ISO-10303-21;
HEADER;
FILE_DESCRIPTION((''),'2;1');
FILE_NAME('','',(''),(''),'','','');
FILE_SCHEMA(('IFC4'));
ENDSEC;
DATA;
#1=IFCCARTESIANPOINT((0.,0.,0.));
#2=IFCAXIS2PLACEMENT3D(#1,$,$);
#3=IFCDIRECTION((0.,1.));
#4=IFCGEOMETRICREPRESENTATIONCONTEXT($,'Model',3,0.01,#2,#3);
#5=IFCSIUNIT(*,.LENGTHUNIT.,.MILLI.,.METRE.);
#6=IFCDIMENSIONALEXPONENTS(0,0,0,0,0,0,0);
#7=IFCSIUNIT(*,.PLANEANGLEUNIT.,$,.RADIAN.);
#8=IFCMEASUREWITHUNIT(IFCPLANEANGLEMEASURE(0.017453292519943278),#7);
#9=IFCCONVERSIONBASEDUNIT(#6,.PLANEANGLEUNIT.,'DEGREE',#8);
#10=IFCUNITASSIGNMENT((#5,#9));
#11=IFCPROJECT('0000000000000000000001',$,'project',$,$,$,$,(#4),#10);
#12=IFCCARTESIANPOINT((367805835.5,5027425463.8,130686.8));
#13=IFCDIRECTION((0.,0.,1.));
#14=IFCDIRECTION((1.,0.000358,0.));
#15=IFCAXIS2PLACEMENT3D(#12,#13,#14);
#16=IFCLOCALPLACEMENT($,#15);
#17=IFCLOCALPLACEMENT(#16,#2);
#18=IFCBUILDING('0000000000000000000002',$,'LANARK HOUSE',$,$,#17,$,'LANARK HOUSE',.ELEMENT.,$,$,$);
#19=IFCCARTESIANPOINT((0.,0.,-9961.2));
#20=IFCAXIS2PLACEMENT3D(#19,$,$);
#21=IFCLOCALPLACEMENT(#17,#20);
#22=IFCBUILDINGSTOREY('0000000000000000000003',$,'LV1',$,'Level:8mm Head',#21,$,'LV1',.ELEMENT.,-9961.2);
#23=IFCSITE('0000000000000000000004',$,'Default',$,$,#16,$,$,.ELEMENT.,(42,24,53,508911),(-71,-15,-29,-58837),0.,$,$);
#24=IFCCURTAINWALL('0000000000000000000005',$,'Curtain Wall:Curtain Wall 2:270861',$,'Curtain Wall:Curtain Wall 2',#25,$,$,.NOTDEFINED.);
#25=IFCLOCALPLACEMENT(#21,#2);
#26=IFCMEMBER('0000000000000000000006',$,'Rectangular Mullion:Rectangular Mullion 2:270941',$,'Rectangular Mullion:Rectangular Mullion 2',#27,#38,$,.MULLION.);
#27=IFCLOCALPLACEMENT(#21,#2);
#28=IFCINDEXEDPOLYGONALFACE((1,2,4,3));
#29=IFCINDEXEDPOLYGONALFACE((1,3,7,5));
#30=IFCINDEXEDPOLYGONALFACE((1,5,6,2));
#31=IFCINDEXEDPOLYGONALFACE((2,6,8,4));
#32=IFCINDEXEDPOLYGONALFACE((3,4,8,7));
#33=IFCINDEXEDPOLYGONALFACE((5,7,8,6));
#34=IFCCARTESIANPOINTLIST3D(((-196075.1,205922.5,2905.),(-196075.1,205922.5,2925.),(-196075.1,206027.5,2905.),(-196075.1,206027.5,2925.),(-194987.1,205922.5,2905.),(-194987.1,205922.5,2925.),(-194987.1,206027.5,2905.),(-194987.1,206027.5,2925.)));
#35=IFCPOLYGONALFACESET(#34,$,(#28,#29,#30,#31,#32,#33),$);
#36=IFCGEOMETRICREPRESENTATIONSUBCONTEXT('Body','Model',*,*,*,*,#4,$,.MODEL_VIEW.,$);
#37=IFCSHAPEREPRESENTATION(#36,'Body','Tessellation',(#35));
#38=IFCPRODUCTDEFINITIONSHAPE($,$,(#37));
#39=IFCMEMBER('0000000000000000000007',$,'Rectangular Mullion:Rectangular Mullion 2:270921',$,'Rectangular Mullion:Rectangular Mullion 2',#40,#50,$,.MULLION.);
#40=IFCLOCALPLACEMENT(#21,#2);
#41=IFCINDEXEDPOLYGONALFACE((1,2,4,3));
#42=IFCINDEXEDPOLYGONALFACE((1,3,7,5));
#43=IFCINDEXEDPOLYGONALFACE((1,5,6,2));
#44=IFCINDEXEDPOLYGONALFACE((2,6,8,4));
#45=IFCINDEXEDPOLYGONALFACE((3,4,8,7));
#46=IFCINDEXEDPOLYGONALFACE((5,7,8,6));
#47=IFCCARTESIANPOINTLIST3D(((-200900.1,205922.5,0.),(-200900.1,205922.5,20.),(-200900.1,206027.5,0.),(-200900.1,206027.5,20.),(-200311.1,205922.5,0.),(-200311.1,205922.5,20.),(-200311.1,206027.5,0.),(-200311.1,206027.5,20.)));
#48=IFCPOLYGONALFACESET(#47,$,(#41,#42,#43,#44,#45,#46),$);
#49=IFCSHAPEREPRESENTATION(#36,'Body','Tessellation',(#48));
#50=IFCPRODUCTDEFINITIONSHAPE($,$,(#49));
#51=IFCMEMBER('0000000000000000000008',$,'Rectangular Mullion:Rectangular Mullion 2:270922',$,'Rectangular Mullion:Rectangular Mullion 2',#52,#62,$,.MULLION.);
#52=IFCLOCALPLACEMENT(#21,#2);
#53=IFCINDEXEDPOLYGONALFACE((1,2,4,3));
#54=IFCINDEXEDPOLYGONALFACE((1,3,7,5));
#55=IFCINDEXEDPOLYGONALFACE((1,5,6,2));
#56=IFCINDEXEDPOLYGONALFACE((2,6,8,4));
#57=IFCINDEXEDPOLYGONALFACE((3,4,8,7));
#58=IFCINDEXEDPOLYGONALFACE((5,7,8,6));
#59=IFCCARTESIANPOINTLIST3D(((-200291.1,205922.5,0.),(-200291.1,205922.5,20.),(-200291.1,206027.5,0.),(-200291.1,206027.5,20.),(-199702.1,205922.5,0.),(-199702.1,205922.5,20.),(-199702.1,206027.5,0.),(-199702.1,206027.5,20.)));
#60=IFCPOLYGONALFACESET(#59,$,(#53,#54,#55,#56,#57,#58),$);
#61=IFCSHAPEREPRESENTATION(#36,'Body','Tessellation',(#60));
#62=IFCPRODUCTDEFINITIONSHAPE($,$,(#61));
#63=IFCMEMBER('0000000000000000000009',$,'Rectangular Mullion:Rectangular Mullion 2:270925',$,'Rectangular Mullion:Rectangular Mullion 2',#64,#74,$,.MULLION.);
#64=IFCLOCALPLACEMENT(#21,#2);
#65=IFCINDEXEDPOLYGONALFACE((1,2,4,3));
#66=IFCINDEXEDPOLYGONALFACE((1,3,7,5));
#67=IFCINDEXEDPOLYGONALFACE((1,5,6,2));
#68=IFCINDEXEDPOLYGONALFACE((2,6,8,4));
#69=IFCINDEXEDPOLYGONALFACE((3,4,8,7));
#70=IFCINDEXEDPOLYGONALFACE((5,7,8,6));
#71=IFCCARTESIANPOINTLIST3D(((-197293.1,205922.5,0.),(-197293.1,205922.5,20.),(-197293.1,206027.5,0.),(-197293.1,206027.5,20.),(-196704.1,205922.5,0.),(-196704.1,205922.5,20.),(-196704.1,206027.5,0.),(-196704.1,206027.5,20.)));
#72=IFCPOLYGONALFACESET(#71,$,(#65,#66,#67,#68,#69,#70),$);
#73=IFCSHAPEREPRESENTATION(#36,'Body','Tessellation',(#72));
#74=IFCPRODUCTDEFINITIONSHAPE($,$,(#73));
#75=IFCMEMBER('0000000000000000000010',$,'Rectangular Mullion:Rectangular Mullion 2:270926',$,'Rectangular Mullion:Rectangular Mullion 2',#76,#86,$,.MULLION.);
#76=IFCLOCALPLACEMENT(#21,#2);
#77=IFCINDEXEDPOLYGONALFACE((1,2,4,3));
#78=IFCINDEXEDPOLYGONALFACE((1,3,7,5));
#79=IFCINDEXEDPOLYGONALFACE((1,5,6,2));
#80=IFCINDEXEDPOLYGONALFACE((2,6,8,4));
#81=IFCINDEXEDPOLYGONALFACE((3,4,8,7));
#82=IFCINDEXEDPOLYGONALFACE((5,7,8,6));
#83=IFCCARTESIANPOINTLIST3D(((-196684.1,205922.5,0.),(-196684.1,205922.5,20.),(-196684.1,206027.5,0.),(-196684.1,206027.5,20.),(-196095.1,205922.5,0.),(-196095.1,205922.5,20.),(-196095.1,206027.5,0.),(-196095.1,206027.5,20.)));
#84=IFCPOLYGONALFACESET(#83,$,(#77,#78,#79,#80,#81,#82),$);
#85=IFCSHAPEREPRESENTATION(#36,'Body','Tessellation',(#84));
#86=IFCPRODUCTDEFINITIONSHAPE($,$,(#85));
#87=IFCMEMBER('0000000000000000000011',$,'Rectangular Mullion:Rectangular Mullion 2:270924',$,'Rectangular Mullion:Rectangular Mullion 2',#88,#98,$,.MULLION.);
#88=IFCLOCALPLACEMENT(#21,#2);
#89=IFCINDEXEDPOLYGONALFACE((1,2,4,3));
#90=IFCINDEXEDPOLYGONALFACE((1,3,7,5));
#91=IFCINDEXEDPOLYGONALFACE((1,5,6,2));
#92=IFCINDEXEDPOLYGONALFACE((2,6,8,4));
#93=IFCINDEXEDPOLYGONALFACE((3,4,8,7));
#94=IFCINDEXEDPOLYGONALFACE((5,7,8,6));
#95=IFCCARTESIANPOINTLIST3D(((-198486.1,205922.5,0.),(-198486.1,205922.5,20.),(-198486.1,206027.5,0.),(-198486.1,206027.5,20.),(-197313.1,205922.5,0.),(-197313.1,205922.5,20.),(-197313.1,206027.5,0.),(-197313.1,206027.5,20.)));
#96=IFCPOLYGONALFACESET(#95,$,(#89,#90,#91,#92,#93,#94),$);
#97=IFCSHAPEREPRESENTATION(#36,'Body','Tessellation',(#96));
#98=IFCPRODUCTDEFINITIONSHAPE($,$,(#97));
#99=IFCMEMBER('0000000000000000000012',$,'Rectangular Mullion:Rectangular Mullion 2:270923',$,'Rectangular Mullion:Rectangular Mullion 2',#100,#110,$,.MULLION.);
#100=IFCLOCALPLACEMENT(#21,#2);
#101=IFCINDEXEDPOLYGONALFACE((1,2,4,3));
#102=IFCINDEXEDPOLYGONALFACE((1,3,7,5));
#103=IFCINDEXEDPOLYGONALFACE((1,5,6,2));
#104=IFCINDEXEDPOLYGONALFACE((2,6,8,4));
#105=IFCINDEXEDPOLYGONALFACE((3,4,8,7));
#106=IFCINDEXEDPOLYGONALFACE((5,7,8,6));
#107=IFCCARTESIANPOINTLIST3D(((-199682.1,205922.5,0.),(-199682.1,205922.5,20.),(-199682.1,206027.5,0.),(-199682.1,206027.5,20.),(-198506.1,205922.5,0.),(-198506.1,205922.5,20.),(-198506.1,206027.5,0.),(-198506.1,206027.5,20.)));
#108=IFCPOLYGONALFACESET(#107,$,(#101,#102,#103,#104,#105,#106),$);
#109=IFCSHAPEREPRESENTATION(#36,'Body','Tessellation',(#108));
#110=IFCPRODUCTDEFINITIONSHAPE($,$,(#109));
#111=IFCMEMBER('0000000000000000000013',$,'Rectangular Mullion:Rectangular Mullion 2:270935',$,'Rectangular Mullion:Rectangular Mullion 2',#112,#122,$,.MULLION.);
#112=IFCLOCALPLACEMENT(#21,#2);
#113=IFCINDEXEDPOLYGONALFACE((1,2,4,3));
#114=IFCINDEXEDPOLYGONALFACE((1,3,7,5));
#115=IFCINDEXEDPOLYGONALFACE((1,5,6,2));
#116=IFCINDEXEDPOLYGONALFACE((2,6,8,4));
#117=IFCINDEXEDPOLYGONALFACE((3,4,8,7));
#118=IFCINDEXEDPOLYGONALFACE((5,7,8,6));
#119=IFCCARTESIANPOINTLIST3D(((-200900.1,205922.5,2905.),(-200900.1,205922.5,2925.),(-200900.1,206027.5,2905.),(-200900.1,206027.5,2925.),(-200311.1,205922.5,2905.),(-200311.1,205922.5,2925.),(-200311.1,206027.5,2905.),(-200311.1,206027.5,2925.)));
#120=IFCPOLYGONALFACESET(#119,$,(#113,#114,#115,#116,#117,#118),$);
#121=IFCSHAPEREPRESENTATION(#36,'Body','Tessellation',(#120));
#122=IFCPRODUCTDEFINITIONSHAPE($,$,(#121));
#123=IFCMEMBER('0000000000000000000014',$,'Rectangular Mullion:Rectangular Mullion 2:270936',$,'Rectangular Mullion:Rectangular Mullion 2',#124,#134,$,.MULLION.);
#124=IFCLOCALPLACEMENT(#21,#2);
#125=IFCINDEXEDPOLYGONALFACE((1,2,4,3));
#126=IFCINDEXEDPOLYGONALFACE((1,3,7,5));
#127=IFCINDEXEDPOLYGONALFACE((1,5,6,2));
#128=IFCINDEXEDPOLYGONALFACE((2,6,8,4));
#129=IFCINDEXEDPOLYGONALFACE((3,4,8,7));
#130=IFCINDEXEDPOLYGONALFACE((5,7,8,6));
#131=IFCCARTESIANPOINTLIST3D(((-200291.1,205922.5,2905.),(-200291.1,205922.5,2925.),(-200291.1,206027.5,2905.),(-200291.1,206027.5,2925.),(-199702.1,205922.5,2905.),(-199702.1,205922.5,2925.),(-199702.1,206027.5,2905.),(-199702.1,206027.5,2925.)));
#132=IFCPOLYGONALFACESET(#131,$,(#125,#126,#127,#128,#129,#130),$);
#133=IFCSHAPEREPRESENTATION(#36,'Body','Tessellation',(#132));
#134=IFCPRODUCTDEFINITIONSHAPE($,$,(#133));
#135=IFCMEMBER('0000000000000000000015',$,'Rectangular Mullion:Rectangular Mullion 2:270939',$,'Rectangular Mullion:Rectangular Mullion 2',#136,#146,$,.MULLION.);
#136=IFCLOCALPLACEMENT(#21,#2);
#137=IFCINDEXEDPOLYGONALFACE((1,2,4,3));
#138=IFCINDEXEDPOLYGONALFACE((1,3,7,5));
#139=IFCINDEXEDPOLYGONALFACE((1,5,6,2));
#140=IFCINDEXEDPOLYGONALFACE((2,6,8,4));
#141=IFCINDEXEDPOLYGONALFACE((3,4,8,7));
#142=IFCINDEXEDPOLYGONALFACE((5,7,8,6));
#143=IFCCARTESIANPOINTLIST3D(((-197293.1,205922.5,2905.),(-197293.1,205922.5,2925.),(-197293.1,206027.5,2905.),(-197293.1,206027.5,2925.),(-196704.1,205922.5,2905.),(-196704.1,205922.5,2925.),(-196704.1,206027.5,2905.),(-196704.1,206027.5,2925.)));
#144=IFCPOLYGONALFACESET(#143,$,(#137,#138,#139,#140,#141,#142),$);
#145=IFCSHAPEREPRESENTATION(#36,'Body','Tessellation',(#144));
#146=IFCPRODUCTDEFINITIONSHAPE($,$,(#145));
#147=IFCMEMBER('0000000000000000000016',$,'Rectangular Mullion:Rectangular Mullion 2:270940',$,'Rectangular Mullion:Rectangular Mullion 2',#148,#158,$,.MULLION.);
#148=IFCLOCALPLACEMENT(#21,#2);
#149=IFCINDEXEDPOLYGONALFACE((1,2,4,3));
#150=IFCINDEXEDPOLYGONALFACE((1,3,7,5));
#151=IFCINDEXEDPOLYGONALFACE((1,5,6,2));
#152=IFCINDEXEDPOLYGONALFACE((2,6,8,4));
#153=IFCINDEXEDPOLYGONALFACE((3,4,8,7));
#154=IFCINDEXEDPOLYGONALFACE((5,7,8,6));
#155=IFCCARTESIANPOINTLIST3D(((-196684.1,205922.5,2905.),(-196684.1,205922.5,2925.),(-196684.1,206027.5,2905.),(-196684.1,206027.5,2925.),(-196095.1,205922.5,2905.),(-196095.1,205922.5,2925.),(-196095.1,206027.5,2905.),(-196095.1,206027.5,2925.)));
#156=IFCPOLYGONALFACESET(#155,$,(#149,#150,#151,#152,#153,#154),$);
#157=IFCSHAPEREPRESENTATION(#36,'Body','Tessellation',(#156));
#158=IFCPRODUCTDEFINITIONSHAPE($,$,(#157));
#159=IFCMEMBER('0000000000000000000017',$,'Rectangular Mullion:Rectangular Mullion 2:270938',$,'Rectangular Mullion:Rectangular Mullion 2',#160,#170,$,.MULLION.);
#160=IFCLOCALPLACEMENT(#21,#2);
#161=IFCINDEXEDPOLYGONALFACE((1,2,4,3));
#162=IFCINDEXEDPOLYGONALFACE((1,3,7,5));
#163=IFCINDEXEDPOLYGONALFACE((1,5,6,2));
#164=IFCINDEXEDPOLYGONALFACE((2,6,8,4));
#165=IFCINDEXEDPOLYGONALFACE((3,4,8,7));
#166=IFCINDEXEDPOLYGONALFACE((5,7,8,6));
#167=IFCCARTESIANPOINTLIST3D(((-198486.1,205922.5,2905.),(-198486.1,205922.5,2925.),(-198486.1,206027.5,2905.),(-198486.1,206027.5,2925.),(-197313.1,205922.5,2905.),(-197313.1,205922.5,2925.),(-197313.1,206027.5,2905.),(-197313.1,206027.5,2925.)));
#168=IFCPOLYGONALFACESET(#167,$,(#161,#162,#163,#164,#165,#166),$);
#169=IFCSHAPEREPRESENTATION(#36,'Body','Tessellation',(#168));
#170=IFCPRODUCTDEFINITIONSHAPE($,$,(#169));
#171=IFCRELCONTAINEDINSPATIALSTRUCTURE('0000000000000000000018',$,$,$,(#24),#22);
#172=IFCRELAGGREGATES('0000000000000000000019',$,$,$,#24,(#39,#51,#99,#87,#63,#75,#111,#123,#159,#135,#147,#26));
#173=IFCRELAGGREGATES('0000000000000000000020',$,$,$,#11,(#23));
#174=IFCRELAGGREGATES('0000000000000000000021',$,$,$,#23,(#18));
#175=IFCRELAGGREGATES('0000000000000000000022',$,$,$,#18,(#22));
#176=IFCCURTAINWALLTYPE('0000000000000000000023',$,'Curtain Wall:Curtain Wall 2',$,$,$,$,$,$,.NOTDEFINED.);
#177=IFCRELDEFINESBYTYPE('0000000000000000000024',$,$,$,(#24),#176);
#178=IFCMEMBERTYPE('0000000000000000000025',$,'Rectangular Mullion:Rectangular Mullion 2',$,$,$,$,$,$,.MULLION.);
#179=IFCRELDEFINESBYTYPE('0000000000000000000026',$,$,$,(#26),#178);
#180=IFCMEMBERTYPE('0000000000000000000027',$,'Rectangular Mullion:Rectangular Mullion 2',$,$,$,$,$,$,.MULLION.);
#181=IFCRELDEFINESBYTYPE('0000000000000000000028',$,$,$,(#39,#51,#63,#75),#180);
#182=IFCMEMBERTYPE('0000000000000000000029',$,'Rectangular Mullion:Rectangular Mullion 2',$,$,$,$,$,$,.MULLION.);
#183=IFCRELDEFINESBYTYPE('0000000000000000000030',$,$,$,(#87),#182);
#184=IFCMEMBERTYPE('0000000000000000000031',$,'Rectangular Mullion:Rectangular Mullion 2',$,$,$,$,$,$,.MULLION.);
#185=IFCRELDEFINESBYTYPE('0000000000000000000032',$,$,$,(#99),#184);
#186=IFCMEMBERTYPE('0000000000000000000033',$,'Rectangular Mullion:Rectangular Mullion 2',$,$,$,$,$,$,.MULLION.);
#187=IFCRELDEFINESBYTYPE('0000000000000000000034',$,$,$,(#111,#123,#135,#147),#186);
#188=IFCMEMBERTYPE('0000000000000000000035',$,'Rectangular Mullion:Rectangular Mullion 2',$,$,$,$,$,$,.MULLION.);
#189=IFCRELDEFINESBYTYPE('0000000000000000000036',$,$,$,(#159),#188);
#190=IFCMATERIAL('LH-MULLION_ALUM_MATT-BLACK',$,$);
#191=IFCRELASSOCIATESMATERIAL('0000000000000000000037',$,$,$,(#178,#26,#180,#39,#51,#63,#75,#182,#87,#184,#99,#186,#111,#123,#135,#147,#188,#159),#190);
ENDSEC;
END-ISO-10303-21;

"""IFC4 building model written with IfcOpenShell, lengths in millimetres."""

from ifc_helpers import new_model, entity, si_unit, converted_unit, direction, frame, origin, place, context, subcontext, project, spatial, indexed_curve, outline, extrude, source, transform, mapped, material, type_object, type_shapes, element, aggregate, save


model = new_model("IFC4")

# Units and contexts
model_context = context("Model", 3, precision=0.01, world=origin(), true_north=direction((0.0, 1.0)))
body_context = subcontext(model_context, "Body", "Model", "MODEL_VIEW")
ifc_project = project(units=[si_unit("LENGTHUNIT", "METRE", prefix="MILLI"), converted_unit("PLANEANGLEUNIT", "DEGREE", entity("IfcPlaneAngleMeasure", 0.017453292519943278), si_unit("PLANEANGLEUNIT", "RADIAN"), dimensions=[0, 0, 0, 0, 0, 0, 0])], contexts=[model_context])

# Site, building, storey
site_placement = place(None, frame((367805835.5, 5027425463.8, 130686.8), z_axis=(0.0, 0.0, 1.0), x_axis=(1.0, 0.000358, 0.0)))
site = spatial("IfcSite", under=ifc_project, at=site_placement, Name="Default", CompositionType="ELEMENT", RefLatitude=(42, 24, 53, 508911), RefLongitude=(-71, -15, -29, -58837), RefElevation=0.0)
building_placement = place(site_placement, origin())
building = spatial("IfcBuilding", under=site, at=building_placement, Name="LANARK HOUSE", LongName="LANARK HOUSE", CompositionType="ELEMENT")
storey_placement = place(building_placement, frame((0.0, 0.0, -9961.2)))
storey = spatial("IfcBuildingStorey", under=building, at=storey_placement, Name="LV1", ObjectType="Level:8mm Head", LongName="LV1", CompositionType="ELEMENT", Elevation=-9961.2)

# Curtain wall, members
curtain_wall_type = type_object("IfcCurtainWallType", Name="Curtain Wall:Curtain Wall 2", PredefinedType="NOTDEFINED")
curtain_wall_placement = place(storey_placement, frame((0.0, 0.0, 9961.2)))
curtain_wall = element("IfcCurtainWall", 1, at=curtain_wall_placement, inside=storey, type_object=curtain_wall_type, Name="Curtain Wall:Curtain Wall 2:270861", ObjectType="Curtain Wall:Curtain Wall 2", PredefinedType="NOTDEFINED")
ifc_material_1 = material(Name="LH-MULLION_ALUM_MATT-BLACK")
member_type_1 = type_object("IfcMemberType", Name="Rectangular Mullion:Rectangular Mullion 2", PredefinedType="MULLION", material=ifc_material_1)
shared_shape_1 = source(origin(), body_context, "Body", "SweptSolid", [
    extrude(outline(indexed_curve([(-10.0, -52.5), (10.0, -52.5), (10.0, 52.5), (-10.0, 52.5), (-10.0, -52.5)], self_intersect=False)), frame((-10.0, -40.0, -1088.0), z_axis=(0.0, 0.0, 1.0), x_axis=(-1.0, 0.0, 0.0)), (0.0, 0.0, 1.0), 1088.0),
])
type_shapes(member_type_1, [shared_shape_1])
member_1_placement = place(curtain_wall_placement, frame((-196075.1, 206015.0, -7036.2), z_axis=(-1.0, 0.0, 0.0), x_axis=(0.0, 0.0, 1.0)))
member_1 = element("IfcMember", 2, at=member_1_placement, type_object=member_type_1, material=ifc_material_1, Name="Rectangular Mullion:Rectangular Mullion 2:270941", ObjectType="Rectangular Mullion:Rectangular Mullion 2", PredefinedType="MULLION", context=body_context, shape_type="MappedRepresentation", body=[
    mapped(shared_shape_1, transform((0.0, 0.0, 0.0), scale=1.0)),
])
member_type_2 = type_object("IfcMemberType", Name="Rectangular Mullion:Rectangular Mullion 2", PredefinedType="MULLION", material=ifc_material_1)
shared_shape_2 = source(origin(), body_context, "Body", "SweptSolid", [
    extrude(outline(indexed_curve([(-10.0, -52.5), (10.0, -52.5), (10.0, 52.5), (-10.0, 52.5), (-10.0, -52.5)], self_intersect=False)), frame((-10.0, -40.0, -589.0), z_axis=(0.0, 0.0, 1.0), x_axis=(-1.0, 0.0, 0.0)), (0.0, 0.0, 1.0), 589.0),
])
type_shapes(member_type_2, [shared_shape_2])
member_2_placement = place(curtain_wall_placement, frame((-200311.1, 206015.0, -9961.2), z_axis=(1.0, 0.0, 0.0), x_axis=(0.0, 0.0, -1.0)))
member_2 = element("IfcMember", 3, at=member_2_placement, type_object=member_type_2, material=ifc_material_1, Name="Rectangular Mullion:Rectangular Mullion 2:270921", ObjectType="Rectangular Mullion:Rectangular Mullion 2", PredefinedType="MULLION", context=body_context, shape_type="MappedRepresentation", body=[
    mapped(shared_shape_2, transform((0.0, 0.0, 0.0), scale=1.0)),
])
member_3_placement = place(curtain_wall_placement, frame((-199702.1, 206015.0, -9961.2), z_axis=(1.0, 0.0, 0.0), x_axis=(0.0, 0.0, -1.0)))
member_3 = element("IfcMember", 4, at=member_3_placement, type_object=member_type_2, material=ifc_material_1, Name="Rectangular Mullion:Rectangular Mullion 2:270922", ObjectType="Rectangular Mullion:Rectangular Mullion 2", PredefinedType="MULLION", context=body_context, shape_type="MappedRepresentation", body=[
    mapped(shared_shape_2, transform((0.0, 0.0, 0.0), scale=1.0)),
])
member_4_placement = place(curtain_wall_placement, frame((-196704.1, 206015.0, -9961.2), z_axis=(1.0, 0.0, 0.0), x_axis=(0.0, 0.0, -1.0)))
member_4 = element("IfcMember", 5, at=member_4_placement, type_object=member_type_2, material=ifc_material_1, Name="Rectangular Mullion:Rectangular Mullion 2:270925", ObjectType="Rectangular Mullion:Rectangular Mullion 2", PredefinedType="MULLION", context=body_context, shape_type="MappedRepresentation", body=[
    mapped(shared_shape_2, transform((0.0, 0.0, 0.0), scale=1.0)),
])
member_5_placement = place(curtain_wall_placement, frame((-196095.1, 206015.0, -9961.2), z_axis=(1.0, 0.0, 0.0), x_axis=(0.0, 0.0, -1.0)))
member_5 = element("IfcMember", 6, at=member_5_placement, type_object=member_type_2, material=ifc_material_1, Name="Rectangular Mullion:Rectangular Mullion 2:270926", ObjectType="Rectangular Mullion:Rectangular Mullion 2", PredefinedType="MULLION", context=body_context, shape_type="MappedRepresentation", body=[
    mapped(shared_shape_2, transform((0.0, 0.0, 0.0), scale=1.0)),
])
member_type_3 = type_object("IfcMemberType", Name="Rectangular Mullion:Rectangular Mullion 2", PredefinedType="MULLION", material=ifc_material_1)
shared_shape_3 = source(origin(), body_context, "Body", "SweptSolid", [
    extrude(outline(indexed_curve([(-10.0, -52.5), (10.0, -52.5), (10.0, 52.5), (-10.0, 52.5), (-10.0, -52.5)], self_intersect=False)), frame((-10.0, -40.0, -1173.0), z_axis=(0.0, 0.0, 1.0), x_axis=(-1.0, 0.0, 0.0)), (0.0, 0.0, 1.0), 1173.0),
])
type_shapes(member_type_3, [shared_shape_3])
member_6_placement = place(curtain_wall_placement, frame((-197313.1, 206015.0, -9961.2), z_axis=(1.0, 0.0, 0.0), x_axis=(0.0, 0.0, -1.0)))
member_6 = element("IfcMember", 7, at=member_6_placement, type_object=member_type_3, material=ifc_material_1, Name="Rectangular Mullion:Rectangular Mullion 2:270924", ObjectType="Rectangular Mullion:Rectangular Mullion 2", PredefinedType="MULLION", context=body_context, shape_type="MappedRepresentation", body=[
    mapped(shared_shape_3, transform((0.0, 0.0, 0.0), scale=1.0)),
])
member_type_4 = type_object("IfcMemberType", Name="Rectangular Mullion:Rectangular Mullion 2", PredefinedType="MULLION", material=ifc_material_1)
shared_shape_4 = source(origin(), body_context, "Body", "SweptSolid", [
    extrude(outline(indexed_curve([(-10.0, -52.5), (10.0, -52.5), (10.0, 52.5), (-10.0, 52.5), (-10.0, -52.5)], self_intersect=False)), frame((-10.0, -40.0, -1176.0), z_axis=(0.0, 0.0, 1.0), x_axis=(-1.0, 0.0, 0.0)), (0.0, 0.0, 1.0), 1176.0),
])
type_shapes(member_type_4, [shared_shape_4])
member_7_placement = place(curtain_wall_placement, frame((-198506.1, 206015.0, -9961.2), z_axis=(1.0, 0.0, 0.0), x_axis=(0.0, 0.0, -1.0)))
member_7 = element("IfcMember", 8, at=member_7_placement, type_object=member_type_4, material=ifc_material_1, Name="Rectangular Mullion:Rectangular Mullion 2:270923", ObjectType="Rectangular Mullion:Rectangular Mullion 2", PredefinedType="MULLION", context=body_context, shape_type="MappedRepresentation", body=[
    mapped(shared_shape_4, transform((0.0, 0.0, 0.0), scale=1.0)),
])
member_type_5 = type_object("IfcMemberType", Name="Rectangular Mullion:Rectangular Mullion 2", PredefinedType="MULLION", material=ifc_material_1)
shared_shape_5 = source(origin(), body_context, "Body", "SweptSolid", [
    extrude(outline(indexed_curve([(-10.0, -52.5), (10.0, -52.5), (10.0, 52.5), (-10.0, 52.5), (-10.0, -52.5)], self_intersect=False)), frame((-10.0, -40.0, -589.0), z_axis=(0.0, 0.0, 1.0), x_axis=(-1.0, 0.0, 0.0)), (0.0, 0.0, 1.0), 589.0),
])
type_shapes(member_type_5, [shared_shape_5])
member_8_placement = place(curtain_wall_placement, frame((-200900.1, 206015.0, -7036.2), z_axis=(-1.0, 0.0, 0.0), x_axis=(0.0, 0.0, 1.0)))
member_8 = element("IfcMember", 9, at=member_8_placement, type_object=member_type_5, material=ifc_material_1, Name="Rectangular Mullion:Rectangular Mullion 2:270935", ObjectType="Rectangular Mullion:Rectangular Mullion 2", PredefinedType="MULLION", context=body_context, shape_type="MappedRepresentation", body=[
    mapped(shared_shape_5, transform((0.0, 0.0, 0.0), scale=1.0)),
])
member_9_placement = place(curtain_wall_placement, frame((-200291.1, 206015.0, -7036.2), z_axis=(-1.0, 0.0, 0.0), x_axis=(0.0, 0.0, 1.0)))
member_9 = element("IfcMember", 10, at=member_9_placement, type_object=member_type_5, material=ifc_material_1, Name="Rectangular Mullion:Rectangular Mullion 2:270936", ObjectType="Rectangular Mullion:Rectangular Mullion 2", PredefinedType="MULLION", context=body_context, shape_type="MappedRepresentation", body=[
    mapped(shared_shape_5, transform((0.0, 0.0, 0.0), scale=1.0)),
])
member_10_placement = place(curtain_wall_placement, frame((-197293.1, 206015.0, -7036.2), z_axis=(-1.0, 0.0, 0.0), x_axis=(0.0, 0.0, 1.0)))
member_10 = element("IfcMember", 11, at=member_10_placement, type_object=member_type_5, material=ifc_material_1, Name="Rectangular Mullion:Rectangular Mullion 2:270939", ObjectType="Rectangular Mullion:Rectangular Mullion 2", PredefinedType="MULLION", context=body_context, shape_type="MappedRepresentation", body=[
    mapped(shared_shape_5, transform((0.0, 0.0, 0.0), scale=1.0)),
])
member_11_placement = place(curtain_wall_placement, frame((-196684.1, 206015.0, -7036.2), z_axis=(-1.0, 0.0, 0.0), x_axis=(0.0, 0.0, 1.0)))
member_11 = element("IfcMember", 12, at=member_11_placement, type_object=member_type_5, material=ifc_material_1, Name="Rectangular Mullion:Rectangular Mullion 2:270940", ObjectType="Rectangular Mullion:Rectangular Mullion 2", PredefinedType="MULLION", context=body_context, shape_type="MappedRepresentation", body=[
    mapped(shared_shape_5, transform((0.0, 0.0, 0.0), scale=1.0)),
])
member_type_6 = type_object("IfcMemberType", Name="Rectangular Mullion:Rectangular Mullion 2", PredefinedType="MULLION", material=ifc_material_1)
shared_shape_6 = source(origin(), body_context, "Body", "SweptSolid", [
    extrude(outline(indexed_curve([(-10.0, -52.5), (10.0, -52.5), (10.0, 52.5), (-10.0, 52.5), (-10.0, -52.5)], self_intersect=False)), frame((-10.0, -40.0, -1173.0), z_axis=(0.0, 0.0, 1.0), x_axis=(-1.0, 0.0, 0.0)), (0.0, 0.0, 1.0), 1173.0),
])
type_shapes(member_type_6, [shared_shape_6])
member_12_placement = place(curtain_wall_placement, frame((-198486.1, 206015.0, -7036.2), z_axis=(-1.0, 0.0, 0.0), x_axis=(0.0, 0.0, 1.0)))
member_12 = element("IfcMember", 13, at=member_12_placement, type_object=member_type_6, material=ifc_material_1, Name="Rectangular Mullion:Rectangular Mullion 2:270938", ObjectType="Rectangular Mullion:Rectangular Mullion 2", PredefinedType="MULLION", context=body_context, shape_type="MappedRepresentation", body=[
    mapped(shared_shape_6, transform((0.0, 0.0, 0.0), scale=1.0)),
])
aggregate(curtain_wall, [member_2, member_3, member_7, member_6, member_4, member_5, member_8, member_9, member_12, member_10, member_11, member_1])

save(model, "model.ifc")
